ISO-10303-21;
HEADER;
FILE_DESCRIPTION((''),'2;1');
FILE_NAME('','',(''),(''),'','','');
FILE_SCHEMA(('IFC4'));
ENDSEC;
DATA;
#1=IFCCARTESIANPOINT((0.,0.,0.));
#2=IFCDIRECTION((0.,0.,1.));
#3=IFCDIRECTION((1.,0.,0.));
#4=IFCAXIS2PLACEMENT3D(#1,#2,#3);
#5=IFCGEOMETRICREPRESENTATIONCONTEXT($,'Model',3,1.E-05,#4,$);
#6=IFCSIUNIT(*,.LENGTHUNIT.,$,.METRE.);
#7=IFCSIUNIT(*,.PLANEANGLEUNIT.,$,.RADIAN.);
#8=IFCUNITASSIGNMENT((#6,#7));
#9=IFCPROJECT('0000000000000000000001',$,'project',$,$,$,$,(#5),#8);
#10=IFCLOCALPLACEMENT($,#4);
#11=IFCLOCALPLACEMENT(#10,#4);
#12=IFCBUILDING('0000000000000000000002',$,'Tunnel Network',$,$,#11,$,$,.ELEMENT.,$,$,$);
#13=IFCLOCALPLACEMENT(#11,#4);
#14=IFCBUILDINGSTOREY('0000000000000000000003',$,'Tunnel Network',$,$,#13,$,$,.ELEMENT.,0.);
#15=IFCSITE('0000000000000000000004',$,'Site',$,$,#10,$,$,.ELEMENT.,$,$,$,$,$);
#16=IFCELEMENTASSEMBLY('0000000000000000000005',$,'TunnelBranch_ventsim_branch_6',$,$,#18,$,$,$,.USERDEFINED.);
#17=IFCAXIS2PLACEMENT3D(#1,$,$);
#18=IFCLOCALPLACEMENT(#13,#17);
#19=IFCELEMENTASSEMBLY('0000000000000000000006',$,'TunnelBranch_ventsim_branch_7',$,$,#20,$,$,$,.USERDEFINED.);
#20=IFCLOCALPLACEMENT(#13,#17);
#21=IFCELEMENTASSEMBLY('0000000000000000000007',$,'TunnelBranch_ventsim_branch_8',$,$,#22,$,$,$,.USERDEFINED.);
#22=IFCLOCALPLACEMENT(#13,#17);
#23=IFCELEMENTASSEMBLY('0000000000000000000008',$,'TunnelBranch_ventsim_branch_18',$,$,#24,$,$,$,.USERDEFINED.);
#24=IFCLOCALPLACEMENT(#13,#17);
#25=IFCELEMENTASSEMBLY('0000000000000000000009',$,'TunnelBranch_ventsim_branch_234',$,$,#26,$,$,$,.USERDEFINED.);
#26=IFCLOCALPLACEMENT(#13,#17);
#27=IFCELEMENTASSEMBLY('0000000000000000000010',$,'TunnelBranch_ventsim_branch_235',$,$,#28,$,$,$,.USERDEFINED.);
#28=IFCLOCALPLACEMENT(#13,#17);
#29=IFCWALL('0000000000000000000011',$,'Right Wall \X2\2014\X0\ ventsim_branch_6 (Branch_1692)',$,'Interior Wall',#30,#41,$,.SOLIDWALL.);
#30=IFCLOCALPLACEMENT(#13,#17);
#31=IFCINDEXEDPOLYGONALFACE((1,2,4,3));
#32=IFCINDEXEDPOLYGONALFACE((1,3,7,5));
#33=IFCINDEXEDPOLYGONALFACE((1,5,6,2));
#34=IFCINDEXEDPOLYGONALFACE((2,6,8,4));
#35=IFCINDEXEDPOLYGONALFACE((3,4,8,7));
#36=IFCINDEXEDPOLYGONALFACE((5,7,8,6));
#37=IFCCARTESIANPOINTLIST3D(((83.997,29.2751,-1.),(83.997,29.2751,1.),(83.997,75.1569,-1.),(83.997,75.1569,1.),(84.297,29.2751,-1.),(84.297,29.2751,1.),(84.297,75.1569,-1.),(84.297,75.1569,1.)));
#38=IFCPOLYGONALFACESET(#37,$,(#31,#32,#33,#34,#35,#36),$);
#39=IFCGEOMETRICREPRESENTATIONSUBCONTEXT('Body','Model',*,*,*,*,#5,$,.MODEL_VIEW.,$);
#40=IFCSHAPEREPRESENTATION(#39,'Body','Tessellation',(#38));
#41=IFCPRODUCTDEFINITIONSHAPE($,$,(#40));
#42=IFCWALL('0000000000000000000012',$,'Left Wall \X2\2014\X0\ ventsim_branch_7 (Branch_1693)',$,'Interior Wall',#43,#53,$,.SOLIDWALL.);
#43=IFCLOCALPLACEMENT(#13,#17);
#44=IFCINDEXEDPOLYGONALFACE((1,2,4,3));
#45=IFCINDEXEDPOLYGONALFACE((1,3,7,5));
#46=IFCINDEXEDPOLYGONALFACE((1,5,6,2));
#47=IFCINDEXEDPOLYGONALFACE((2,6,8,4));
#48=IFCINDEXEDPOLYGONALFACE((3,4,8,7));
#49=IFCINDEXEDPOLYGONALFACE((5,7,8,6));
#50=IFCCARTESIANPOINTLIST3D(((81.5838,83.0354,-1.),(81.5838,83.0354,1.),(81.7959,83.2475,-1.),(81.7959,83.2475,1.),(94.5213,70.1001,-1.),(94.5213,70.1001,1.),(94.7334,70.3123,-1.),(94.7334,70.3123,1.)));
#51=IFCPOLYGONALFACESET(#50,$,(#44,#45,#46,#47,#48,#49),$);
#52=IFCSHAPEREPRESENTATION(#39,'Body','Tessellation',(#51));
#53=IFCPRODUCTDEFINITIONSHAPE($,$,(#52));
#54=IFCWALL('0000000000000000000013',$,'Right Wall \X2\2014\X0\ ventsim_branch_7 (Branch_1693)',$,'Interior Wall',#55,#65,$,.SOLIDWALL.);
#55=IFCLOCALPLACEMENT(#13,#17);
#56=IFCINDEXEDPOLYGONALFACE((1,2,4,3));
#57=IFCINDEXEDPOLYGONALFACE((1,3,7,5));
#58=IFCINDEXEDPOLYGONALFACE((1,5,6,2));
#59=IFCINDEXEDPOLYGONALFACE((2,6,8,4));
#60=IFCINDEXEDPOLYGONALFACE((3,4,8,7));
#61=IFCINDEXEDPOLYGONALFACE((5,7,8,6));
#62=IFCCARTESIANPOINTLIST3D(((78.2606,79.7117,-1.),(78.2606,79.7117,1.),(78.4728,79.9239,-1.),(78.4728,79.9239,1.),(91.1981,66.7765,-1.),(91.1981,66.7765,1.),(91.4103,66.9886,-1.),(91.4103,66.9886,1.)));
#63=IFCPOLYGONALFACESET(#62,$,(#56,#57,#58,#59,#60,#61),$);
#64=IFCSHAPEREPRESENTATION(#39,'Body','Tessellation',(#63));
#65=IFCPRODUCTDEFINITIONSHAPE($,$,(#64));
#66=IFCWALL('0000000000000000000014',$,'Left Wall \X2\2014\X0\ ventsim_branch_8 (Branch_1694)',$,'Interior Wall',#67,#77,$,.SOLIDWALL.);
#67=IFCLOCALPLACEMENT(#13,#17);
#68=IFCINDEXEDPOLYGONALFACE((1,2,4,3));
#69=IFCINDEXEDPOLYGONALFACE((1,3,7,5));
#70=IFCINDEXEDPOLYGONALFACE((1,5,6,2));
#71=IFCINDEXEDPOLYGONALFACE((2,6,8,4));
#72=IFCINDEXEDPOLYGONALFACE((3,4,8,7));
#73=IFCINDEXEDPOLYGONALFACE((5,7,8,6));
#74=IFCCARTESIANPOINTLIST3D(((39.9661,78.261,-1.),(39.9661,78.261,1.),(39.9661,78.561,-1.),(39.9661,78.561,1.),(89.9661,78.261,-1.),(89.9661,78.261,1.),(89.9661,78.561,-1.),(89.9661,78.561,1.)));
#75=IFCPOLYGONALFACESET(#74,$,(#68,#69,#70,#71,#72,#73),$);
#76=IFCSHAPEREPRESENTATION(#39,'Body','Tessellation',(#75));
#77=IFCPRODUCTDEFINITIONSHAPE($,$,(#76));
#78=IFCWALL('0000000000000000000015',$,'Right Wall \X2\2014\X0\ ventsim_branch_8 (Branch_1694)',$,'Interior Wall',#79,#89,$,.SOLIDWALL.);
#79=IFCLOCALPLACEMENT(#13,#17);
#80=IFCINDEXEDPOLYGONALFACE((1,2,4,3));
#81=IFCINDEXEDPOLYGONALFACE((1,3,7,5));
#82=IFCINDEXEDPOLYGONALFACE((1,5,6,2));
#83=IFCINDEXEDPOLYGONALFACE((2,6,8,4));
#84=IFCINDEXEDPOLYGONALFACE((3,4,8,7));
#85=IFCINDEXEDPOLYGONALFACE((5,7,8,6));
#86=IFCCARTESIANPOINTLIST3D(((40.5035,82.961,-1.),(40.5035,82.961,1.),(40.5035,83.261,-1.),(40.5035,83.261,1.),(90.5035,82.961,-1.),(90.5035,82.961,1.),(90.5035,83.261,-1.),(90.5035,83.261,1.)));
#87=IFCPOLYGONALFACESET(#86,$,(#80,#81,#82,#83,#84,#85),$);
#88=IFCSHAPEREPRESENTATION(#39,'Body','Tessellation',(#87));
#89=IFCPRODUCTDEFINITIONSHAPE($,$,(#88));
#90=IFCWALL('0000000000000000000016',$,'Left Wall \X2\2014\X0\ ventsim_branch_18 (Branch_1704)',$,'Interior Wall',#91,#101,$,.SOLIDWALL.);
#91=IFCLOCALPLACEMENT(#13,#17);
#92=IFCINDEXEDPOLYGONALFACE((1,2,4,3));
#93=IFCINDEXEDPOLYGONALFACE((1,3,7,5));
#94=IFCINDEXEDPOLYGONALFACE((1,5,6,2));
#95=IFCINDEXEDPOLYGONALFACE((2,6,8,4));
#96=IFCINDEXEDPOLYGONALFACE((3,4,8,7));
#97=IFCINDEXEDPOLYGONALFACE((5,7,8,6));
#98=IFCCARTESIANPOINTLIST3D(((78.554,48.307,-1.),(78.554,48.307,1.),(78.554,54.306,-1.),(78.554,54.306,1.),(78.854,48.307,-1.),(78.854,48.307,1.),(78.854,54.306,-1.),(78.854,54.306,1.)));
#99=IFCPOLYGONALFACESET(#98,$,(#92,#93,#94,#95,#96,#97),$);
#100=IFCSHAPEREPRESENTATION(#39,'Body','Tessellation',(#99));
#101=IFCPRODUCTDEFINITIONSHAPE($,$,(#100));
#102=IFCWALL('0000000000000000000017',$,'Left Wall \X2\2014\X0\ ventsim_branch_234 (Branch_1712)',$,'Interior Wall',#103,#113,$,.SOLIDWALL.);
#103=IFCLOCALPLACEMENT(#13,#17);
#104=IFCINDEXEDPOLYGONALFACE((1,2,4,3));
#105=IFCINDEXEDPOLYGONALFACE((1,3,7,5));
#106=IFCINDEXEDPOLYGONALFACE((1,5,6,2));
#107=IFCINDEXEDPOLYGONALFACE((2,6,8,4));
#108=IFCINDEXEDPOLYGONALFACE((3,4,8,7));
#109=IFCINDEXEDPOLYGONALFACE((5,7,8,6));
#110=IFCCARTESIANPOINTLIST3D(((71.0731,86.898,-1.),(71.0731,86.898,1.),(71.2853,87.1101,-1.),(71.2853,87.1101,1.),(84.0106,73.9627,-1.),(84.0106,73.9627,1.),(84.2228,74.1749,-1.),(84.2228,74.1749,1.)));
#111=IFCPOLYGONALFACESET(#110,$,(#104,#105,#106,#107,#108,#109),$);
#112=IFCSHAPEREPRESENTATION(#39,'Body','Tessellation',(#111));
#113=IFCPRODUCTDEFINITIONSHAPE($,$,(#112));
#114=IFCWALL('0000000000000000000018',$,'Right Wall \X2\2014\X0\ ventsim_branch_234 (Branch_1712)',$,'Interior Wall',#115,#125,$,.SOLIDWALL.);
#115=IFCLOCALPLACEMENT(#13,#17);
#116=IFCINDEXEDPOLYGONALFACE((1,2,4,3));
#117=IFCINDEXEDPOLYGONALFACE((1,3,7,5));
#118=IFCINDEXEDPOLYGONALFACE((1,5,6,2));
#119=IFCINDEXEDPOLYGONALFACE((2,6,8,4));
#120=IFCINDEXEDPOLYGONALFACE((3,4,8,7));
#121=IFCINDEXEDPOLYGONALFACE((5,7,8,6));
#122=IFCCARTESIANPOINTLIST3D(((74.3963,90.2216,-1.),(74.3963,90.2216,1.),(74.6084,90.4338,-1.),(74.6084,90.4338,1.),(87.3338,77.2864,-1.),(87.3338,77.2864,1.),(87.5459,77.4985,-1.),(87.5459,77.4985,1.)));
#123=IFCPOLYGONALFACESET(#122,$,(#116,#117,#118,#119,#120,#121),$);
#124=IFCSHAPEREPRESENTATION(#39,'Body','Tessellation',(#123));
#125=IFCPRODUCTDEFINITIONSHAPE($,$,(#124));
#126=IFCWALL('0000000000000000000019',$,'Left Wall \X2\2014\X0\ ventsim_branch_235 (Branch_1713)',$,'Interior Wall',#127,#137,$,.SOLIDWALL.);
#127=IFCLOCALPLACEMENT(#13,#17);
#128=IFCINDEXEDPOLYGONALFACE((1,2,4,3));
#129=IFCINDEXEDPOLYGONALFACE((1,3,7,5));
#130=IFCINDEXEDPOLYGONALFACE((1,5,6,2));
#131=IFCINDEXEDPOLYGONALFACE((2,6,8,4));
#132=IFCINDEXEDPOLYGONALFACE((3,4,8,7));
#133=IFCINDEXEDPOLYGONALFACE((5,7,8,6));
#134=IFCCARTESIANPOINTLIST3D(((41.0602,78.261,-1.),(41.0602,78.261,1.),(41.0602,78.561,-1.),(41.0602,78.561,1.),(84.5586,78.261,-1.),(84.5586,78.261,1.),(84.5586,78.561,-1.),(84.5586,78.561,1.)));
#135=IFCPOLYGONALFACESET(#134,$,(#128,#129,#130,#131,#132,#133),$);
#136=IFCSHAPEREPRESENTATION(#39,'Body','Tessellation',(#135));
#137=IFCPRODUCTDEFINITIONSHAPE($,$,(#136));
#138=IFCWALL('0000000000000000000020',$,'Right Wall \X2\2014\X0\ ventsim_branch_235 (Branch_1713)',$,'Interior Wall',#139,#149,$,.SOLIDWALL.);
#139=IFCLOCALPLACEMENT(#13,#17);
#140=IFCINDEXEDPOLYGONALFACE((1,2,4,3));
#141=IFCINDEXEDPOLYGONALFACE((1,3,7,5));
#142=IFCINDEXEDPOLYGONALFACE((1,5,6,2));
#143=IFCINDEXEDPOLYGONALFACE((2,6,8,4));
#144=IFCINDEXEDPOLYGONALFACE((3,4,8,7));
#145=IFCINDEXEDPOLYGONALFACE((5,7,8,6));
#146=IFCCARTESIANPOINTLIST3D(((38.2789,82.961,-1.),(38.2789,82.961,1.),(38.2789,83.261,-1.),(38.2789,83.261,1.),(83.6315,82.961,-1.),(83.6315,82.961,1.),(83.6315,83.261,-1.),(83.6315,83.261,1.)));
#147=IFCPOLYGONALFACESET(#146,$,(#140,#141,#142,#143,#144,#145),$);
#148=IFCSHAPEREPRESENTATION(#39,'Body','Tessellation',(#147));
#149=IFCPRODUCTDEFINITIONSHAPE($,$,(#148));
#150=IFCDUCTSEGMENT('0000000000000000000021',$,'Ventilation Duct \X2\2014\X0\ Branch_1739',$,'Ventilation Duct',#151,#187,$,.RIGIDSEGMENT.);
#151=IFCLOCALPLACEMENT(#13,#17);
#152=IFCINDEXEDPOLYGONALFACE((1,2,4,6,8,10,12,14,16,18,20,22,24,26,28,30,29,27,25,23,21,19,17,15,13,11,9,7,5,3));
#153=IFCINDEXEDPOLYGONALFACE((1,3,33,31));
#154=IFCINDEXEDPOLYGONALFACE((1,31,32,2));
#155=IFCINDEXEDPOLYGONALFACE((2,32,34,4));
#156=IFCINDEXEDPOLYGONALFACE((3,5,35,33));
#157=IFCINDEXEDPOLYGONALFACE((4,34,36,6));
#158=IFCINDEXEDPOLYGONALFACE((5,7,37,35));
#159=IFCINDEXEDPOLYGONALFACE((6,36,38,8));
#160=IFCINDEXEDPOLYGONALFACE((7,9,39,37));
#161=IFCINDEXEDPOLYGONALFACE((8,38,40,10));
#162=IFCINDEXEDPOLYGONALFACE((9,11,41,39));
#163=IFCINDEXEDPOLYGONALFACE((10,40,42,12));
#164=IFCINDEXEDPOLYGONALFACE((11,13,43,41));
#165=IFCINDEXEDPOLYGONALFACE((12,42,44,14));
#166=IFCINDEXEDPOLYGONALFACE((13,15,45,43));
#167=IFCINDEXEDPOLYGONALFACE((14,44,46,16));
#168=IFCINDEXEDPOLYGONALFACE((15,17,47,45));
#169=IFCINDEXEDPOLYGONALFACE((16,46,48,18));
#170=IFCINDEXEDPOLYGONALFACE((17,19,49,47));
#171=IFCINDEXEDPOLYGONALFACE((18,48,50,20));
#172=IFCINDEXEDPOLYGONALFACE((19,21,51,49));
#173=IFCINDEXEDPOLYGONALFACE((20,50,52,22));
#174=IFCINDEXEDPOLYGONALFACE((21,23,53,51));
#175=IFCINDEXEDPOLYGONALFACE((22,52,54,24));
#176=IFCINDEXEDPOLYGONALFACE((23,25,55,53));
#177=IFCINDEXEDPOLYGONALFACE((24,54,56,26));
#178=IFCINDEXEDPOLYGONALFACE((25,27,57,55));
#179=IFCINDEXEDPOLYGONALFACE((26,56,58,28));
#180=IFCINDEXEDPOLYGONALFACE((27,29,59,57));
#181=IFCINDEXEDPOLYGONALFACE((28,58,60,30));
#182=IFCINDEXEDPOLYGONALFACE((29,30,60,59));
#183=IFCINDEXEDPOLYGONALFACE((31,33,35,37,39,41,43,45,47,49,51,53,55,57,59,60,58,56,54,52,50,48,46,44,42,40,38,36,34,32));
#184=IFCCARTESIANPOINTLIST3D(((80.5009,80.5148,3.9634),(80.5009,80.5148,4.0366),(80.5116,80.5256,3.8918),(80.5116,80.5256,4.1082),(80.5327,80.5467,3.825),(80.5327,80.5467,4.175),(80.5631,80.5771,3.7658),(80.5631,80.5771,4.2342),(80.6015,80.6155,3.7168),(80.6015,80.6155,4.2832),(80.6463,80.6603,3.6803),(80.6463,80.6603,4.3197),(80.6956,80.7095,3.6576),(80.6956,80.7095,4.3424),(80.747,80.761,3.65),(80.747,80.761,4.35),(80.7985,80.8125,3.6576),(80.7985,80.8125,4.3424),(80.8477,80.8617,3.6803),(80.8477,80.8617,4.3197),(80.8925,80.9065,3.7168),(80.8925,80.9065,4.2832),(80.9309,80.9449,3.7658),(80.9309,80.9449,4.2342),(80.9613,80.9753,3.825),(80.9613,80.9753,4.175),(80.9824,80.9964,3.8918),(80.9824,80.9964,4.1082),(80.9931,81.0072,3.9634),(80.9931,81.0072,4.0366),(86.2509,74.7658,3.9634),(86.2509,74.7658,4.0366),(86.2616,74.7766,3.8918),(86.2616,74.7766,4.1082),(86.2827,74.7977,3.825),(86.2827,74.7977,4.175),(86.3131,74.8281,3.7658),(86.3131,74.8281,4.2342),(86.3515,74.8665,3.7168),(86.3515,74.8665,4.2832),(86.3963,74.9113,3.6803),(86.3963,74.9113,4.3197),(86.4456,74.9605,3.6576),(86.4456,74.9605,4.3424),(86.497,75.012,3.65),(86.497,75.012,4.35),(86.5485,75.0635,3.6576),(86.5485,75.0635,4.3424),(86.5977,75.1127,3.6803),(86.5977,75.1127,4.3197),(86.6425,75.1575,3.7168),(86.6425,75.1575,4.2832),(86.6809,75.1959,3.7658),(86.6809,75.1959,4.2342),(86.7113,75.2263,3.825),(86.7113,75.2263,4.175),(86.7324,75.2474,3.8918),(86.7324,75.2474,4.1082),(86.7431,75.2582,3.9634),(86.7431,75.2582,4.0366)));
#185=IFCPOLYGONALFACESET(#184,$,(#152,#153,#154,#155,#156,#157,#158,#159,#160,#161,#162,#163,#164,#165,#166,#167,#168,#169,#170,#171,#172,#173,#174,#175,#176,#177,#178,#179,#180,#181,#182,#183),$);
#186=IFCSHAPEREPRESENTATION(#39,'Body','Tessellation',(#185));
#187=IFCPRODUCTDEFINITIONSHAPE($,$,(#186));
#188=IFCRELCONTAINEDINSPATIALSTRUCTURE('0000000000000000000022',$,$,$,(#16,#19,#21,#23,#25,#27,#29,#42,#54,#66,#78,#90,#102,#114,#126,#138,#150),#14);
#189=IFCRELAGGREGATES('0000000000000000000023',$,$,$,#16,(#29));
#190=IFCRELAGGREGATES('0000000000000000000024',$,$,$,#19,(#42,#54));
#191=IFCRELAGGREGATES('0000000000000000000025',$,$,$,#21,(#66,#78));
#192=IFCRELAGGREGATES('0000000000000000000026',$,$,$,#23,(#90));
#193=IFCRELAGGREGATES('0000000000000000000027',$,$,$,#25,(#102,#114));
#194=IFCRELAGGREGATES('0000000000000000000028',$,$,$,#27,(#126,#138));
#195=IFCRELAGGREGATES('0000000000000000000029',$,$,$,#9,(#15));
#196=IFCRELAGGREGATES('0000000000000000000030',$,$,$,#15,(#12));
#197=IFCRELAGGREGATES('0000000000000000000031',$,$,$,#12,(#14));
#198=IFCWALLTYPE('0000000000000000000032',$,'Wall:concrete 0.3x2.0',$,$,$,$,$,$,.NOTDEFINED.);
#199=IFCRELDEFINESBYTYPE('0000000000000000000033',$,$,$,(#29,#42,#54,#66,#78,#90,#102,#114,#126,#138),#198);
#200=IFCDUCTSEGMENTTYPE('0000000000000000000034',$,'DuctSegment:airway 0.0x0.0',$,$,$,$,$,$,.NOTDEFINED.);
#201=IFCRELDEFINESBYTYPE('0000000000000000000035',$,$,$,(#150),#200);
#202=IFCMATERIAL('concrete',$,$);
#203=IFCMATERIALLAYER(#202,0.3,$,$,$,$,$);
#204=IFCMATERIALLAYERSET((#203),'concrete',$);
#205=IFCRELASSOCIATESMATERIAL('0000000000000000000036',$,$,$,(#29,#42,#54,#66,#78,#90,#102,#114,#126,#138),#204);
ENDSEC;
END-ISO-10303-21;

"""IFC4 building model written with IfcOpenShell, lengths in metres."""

from ifc_helpers import new_model, si_unit, frame, origin_with_axes, origin_2d_with_axis, place, context, subcontext, project, spatial, rectangle, circle, extrude, material, layer, layer_set, layer_usage, type_object, element, aggregate, save


model = new_model("IFC4")

# Units and contexts
model_context = context("Model", 3, precision=1e-05, world=origin_with_axes())
body_context = subcontext(model_context, "Body", "Model", "MODEL_VIEW")
ifc_project = project(units=[si_unit("LENGTHUNIT", "METRE"), si_unit("PLANEANGLEUNIT", "RADIAN")], contexts=[model_context])

# Site, building, storey
site_placement = place(None, origin_with_axes())
site = spatial("IfcSite", under=ifc_project, at=site_placement, Name="Site", CompositionType="ELEMENT")
building_placement = place(site_placement, origin_with_axes())
building = spatial("IfcBuilding", under=site, at=building_placement, Name="Tunnel Network", CompositionType="ELEMENT")
storey_placement = place(building_placement, origin_with_axes())
storey = spatial("IfcBuildingStorey", under=building, at=storey_placement, Name="Tunnel Network", CompositionType="ELEMENT", Elevation=0.0)

# Element assemblies
assembly_1_placement = place(storey_placement, frame((88.847, 75.1569, 0.0), z_axis=(0.0, -1.0, 0.0), x_axis=(-1.0, 0.0, 0.0)))
assembly_1 = element("IfcElementAssembly", 1, at=assembly_1_placement, inside=storey, Name="TunnelBranch_ventsim_branch_6", PredefinedType="USERDEFINED")
ifc_material = material(Name="concrete")
ifc_layer = layer(ifc_material, 0.3)
ifc_layer_set = layer_set([ifc_layer], Name="concrete")
assembly_2_placement = place(storey_placement, frame((81.6898, 83.1415, 0.0), z_axis=(0.707168, -0.707045, 0.0), x_axis=(-0.707045, -0.707168, 0.0)))
assembly_2 = element("IfcElementAssembly", 2, at=assembly_2_placement, inside=storey, Name="TunnelBranch_ventsim_branch_7", PredefinedType="USERDEFINED")
assembly_3_placement = place(storey_placement, frame((89.9661, 78.411, 0.0), z_axis=(-1.0, 0.0, 0.0), x_axis=(0.0, 1.0, 0.0)))
assembly_3 = element("IfcElementAssembly", 3, at=assembly_3_placement, inside=storey, Name="TunnelBranch_ventsim_branch_8", PredefinedType="USERDEFINED")
assembly_4_placement = place(storey_placement, frame((78.704, 54.306, 0.0), z_axis=(0.0, -1.0, 0.0), x_axis=(-1.0, 0.0, 0.0)))
assembly_4 = element("IfcElementAssembly", 4, at=assembly_4_placement, inside=storey, Name="TunnelBranch_ventsim_branch_18", PredefinedType="USERDEFINED")
assembly_5_placement = place(storey_placement, frame((84.1167, 74.0688, 0.0), z_axis=(-0.707168, 0.707045, 0.0), x_axis=(0.707045, 0.707168, 0.0)))
assembly_5 = element("IfcElementAssembly", 5, at=assembly_5_placement, inside=storey, Name="TunnelBranch_ventsim_branch_234", PredefinedType="USERDEFINED")
assembly_6_placement = place(storey_placement, frame((84.5586, 78.411, 0.0), z_axis=(-1.0, 0.0, 0.0), x_axis=(0.0, 1.0, 0.0)))
assembly_6 = element("IfcElementAssembly", 6, at=assembly_6_placement, inside=storey, Name="TunnelBranch_ventsim_branch_235", PredefinedType="USERDEFINED")

# Shared definitions
wall_type = type_object("IfcWallType", Name="Wall:concrete 0.3x2.0")

# Walls
ifc_layer_usage_1 = layer_usage(ifc_layer_set, "AXIS2", "POSITIVE", 0.0)
wall_1_placement = place(storey_placement, frame((84.147, 75.1569, 0.0), z_axis=(0.0, -1.0, 0.0), x_axis=(-1.0, 0.0, 0.0)))
wall_1 = element("IfcWall", 7, at=wall_1_placement, inside=storey, type_object=wall_type, material=ifc_layer_usage_1, Name="Right Wall — ventsim_branch_6 (Branch_1692)", ObjectType="Interior Wall", PredefinedType="SOLIDWALL", context=body_context, shape_type="SweptSolid", body=[
    extrude(rectangle(XDim=0.3, YDim=2.0, at=origin_2d_with_axis()), origin_with_axes(), (0.0, 0.0, 1.0), 45.8817),
])
aggregate(assembly_1, [wall_1])
ifc_layer_usage_2 = layer_usage(ifc_layer_set, "AXIS2", "POSITIVE", 0.0)
wall_2_placement = place(storey_placement, frame((81.6898, 83.1415, 0.0), z_axis=(0.707168, -0.707045, 0.0), x_axis=(-0.707045, -0.707168, 0.0)))
wall_2 = element("IfcWall", 8, at=wall_2_placement, inside=storey, type_object=wall_type, material=ifc_layer_usage_2, Name="Left Wall — ventsim_branch_7 (Branch_1693)", ObjectType="Interior Wall", PredefinedType="SOLIDWALL", context=body_context, shape_type="SweptSolid", body=[
    extrude(rectangle(XDim=0.3, YDim=2.0, at=origin_2d_with_axis()), origin_with_axes(), (0.0, 0.0, 1.0), 18.2948),
])
ifc_layer_usage_3 = layer_usage(ifc_layer_set, "AXIS2", "POSITIVE", 0.0)
wall_3_placement = place(storey_placement, frame((78.3667, 79.8178, 0.0), z_axis=(0.707168, -0.707045, 0.0), x_axis=(-0.707045, -0.707168, 0.0)))
wall_3 = element("IfcWall", 9, at=wall_3_placement, inside=storey, type_object=wall_type, material=ifc_layer_usage_3, Name="Right Wall — ventsim_branch_7 (Branch_1693)", ObjectType="Interior Wall", PredefinedType="SOLIDWALL", context=body_context, shape_type="SweptSolid", body=[
    extrude(rectangle(XDim=0.3, YDim=2.0, at=origin_2d_with_axis()), origin_with_axes(), (0.0, 0.0, 1.0), 18.2948),
])
aggregate(assembly_2, [wall_2, wall_3])
ifc_layer_usage_4 = layer_usage(ifc_layer_set, "AXIS2", "POSITIVE", 0.0)
wall_4_placement = place(storey_placement, frame((89.9661, 78.411, 0.0), z_axis=(-1.0, 0.0, 0.0), x_axis=(0.0, 1.0, 0.0)))
wall_4 = element("IfcWall", 10, at=wall_4_placement, inside=storey, type_object=wall_type, material=ifc_layer_usage_4, Name="Left Wall — ventsim_branch_8 (Branch_1694)", ObjectType="Interior Wall", PredefinedType="SOLIDWALL", context=body_context, shape_type="SweptSolid", body=[
    extrude(rectangle(XDim=0.3, YDim=2.0, at=origin_2d_with_axis()), origin_with_axes(), (0.0, 0.0, 1.0), 50.0),
])
ifc_layer_usage_5 = layer_usage(ifc_layer_set, "AXIS2", "POSITIVE", 0.0)
wall_5_placement = place(storey_placement, frame((90.5035, 83.111, 0.0), z_axis=(-1.0, 0.0, 0.0), x_axis=(0.0, 1.0, 0.0)))
wall_5 = element("IfcWall", 11, at=wall_5_placement, inside=storey, type_object=wall_type, material=ifc_layer_usage_5, Name="Right Wall — ventsim_branch_8 (Branch_1694)", ObjectType="Interior Wall", PredefinedType="SOLIDWALL", context=body_context, shape_type="SweptSolid", body=[
    extrude(rectangle(XDim=0.3, YDim=2.0, at=origin_2d_with_axis()), origin_with_axes(), (0.0, 0.0, 1.0), 50.0),
])
aggregate(assembly_3, [wall_4, wall_5])
ifc_layer_usage_6 = layer_usage(ifc_layer_set, "AXIS2", "POSITIVE", 0.0)
wall_6_placement = place(storey_placement, frame((78.704, 54.306, 0.0), z_axis=(0.0, -1.0, 0.0), x_axis=(-1.0, 0.0, 0.0)))
wall_6 = element("IfcWall", 12, at=wall_6_placement, inside=storey, type_object=wall_type, material=ifc_layer_usage_6, Name="Left Wall — ventsim_branch_18 (Branch_1704)", ObjectType="Interior Wall", PredefinedType="SOLIDWALL", context=body_context, shape_type="SweptSolid", body=[
    extrude(rectangle(XDim=0.3, YDim=2.0, at=origin_2d_with_axis()), origin_with_axes(), (0.0, 0.0, 1.0), 5.999),
])
aggregate(assembly_4, [wall_6])
ifc_layer_usage_7 = layer_usage(ifc_layer_set, "AXIS2", "POSITIVE", 0.0)
wall_7_placement = place(storey_placement, frame((84.1167, 74.0688, 0.0), z_axis=(-0.707168, 0.707045, 0.0), x_axis=(0.707045, 0.707168, 0.0)))
wall_7 = element("IfcWall", 13, at=wall_7_placement, inside=storey, type_object=wall_type, material=ifc_layer_usage_7, Name="Left Wall — ventsim_branch_234 (Branch_1712)", ObjectType="Interior Wall", PredefinedType="SOLIDWALL", context=body_context, shape_type="SweptSolid", body=[
    extrude(rectangle(XDim=0.3, YDim=2.0, at=origin_2d_with_axis()), origin_with_axes(), (0.0, 0.0, 1.0), 18.2948),
])
ifc_layer_usage_8 = layer_usage(ifc_layer_set, "AXIS2", "POSITIVE", 0.0)
wall_8_placement = place(storey_placement, frame((87.4398, 77.3925, 0.0), z_axis=(-0.707168, 0.707045, 0.0), x_axis=(0.707045, 0.707168, 0.0)))
wall_8 = element("IfcWall", 14, at=wall_8_placement, inside=storey, type_object=wall_type, material=ifc_layer_usage_8, Name="Right Wall — ventsim_branch_234 (Branch_1712)", ObjectType="Interior Wall", PredefinedType="SOLIDWALL", context=body_context, shape_type="SweptSolid", body=[
    extrude(rectangle(XDim=0.3, YDim=2.0, at=origin_2d_with_axis()), origin_with_axes(), (0.0, 0.0, 1.0), 18.2948),
])
aggregate(assembly_5, [wall_7, wall_8])
ifc_layer_usage_9 = layer_usage(ifc_layer_set, "AXIS2", "POSITIVE", 0.0)
wall_9_placement = place(storey_placement, frame((84.5586, 78.411, 0.0), z_axis=(-1.0, 0.0, 0.0), x_axis=(0.0, 1.0, 0.0)))
wall_9 = element("IfcWall", 15, at=wall_9_placement, inside=storey, type_object=wall_type, material=ifc_layer_usage_9, Name="Left Wall — ventsim_branch_235 (Branch_1713)", ObjectType="Interior Wall", PredefinedType="SOLIDWALL", context=body_context, shape_type="SweptSolid", body=[
    extrude(rectangle(XDim=0.3, YDim=2.0, at=origin_2d_with_axis()), origin_with_axes(), (0.0, 0.0, 1.0), 43.4984),
])
ifc_layer_usage_10 = layer_usage(ifc_layer_set, "AXIS2", "POSITIVE", 0.0)
wall_10_placement = place(storey_placement, frame((83.6315, 83.111, 0.0), z_axis=(-1.0, 0.0, 0.0), x_axis=(0.0, 1.0, 0.0)))
wall_10 = element("IfcWall", 16, at=wall_10_placement, inside=storey, type_object=wall_type, material=ifc_layer_usage_10, Name="Right Wall — ventsim_branch_235 (Branch_1713)", ObjectType="Interior Wall", PredefinedType="SOLIDWALL", context=body_context, shape_type="SweptSolid", body=[
    extrude(rectangle(XDim=0.3, YDim=2.0, at=origin_2d_with_axis()), origin_with_axes(), (0.0, 0.0, 1.0), 45.3526),
])
aggregate(assembly_6, [wall_9, wall_10])

# Duct segment
duct_segment_type = type_object("IfcDuctSegmentType", Name="DuctSegment:airway 0.0x0.0")
duct_segment_1_placement = place(storey_placement, frame((86.497, 75.012, 4.0), z_axis=(-0.707168, 0.707045, 0.0), x_axis=(0.0, 0.0, 1.0)))
element("IfcDuctSegment", 17, at=duct_segment_1_placement, inside=storey, type_object=duct_segment_type, Name="Ventilation Duct — Branch_1739", ObjectType="Ventilation Duct", PredefinedType="RIGIDSEGMENT", context=body_context, shape_type="SweptSolid", body=[
    extrude(circle(Radius=0.35, at=origin_2d_with_axis()), origin_with_axes(), (0.0, 0.0, 1.0), 8.131),
])

save(model, "model.ifc")
